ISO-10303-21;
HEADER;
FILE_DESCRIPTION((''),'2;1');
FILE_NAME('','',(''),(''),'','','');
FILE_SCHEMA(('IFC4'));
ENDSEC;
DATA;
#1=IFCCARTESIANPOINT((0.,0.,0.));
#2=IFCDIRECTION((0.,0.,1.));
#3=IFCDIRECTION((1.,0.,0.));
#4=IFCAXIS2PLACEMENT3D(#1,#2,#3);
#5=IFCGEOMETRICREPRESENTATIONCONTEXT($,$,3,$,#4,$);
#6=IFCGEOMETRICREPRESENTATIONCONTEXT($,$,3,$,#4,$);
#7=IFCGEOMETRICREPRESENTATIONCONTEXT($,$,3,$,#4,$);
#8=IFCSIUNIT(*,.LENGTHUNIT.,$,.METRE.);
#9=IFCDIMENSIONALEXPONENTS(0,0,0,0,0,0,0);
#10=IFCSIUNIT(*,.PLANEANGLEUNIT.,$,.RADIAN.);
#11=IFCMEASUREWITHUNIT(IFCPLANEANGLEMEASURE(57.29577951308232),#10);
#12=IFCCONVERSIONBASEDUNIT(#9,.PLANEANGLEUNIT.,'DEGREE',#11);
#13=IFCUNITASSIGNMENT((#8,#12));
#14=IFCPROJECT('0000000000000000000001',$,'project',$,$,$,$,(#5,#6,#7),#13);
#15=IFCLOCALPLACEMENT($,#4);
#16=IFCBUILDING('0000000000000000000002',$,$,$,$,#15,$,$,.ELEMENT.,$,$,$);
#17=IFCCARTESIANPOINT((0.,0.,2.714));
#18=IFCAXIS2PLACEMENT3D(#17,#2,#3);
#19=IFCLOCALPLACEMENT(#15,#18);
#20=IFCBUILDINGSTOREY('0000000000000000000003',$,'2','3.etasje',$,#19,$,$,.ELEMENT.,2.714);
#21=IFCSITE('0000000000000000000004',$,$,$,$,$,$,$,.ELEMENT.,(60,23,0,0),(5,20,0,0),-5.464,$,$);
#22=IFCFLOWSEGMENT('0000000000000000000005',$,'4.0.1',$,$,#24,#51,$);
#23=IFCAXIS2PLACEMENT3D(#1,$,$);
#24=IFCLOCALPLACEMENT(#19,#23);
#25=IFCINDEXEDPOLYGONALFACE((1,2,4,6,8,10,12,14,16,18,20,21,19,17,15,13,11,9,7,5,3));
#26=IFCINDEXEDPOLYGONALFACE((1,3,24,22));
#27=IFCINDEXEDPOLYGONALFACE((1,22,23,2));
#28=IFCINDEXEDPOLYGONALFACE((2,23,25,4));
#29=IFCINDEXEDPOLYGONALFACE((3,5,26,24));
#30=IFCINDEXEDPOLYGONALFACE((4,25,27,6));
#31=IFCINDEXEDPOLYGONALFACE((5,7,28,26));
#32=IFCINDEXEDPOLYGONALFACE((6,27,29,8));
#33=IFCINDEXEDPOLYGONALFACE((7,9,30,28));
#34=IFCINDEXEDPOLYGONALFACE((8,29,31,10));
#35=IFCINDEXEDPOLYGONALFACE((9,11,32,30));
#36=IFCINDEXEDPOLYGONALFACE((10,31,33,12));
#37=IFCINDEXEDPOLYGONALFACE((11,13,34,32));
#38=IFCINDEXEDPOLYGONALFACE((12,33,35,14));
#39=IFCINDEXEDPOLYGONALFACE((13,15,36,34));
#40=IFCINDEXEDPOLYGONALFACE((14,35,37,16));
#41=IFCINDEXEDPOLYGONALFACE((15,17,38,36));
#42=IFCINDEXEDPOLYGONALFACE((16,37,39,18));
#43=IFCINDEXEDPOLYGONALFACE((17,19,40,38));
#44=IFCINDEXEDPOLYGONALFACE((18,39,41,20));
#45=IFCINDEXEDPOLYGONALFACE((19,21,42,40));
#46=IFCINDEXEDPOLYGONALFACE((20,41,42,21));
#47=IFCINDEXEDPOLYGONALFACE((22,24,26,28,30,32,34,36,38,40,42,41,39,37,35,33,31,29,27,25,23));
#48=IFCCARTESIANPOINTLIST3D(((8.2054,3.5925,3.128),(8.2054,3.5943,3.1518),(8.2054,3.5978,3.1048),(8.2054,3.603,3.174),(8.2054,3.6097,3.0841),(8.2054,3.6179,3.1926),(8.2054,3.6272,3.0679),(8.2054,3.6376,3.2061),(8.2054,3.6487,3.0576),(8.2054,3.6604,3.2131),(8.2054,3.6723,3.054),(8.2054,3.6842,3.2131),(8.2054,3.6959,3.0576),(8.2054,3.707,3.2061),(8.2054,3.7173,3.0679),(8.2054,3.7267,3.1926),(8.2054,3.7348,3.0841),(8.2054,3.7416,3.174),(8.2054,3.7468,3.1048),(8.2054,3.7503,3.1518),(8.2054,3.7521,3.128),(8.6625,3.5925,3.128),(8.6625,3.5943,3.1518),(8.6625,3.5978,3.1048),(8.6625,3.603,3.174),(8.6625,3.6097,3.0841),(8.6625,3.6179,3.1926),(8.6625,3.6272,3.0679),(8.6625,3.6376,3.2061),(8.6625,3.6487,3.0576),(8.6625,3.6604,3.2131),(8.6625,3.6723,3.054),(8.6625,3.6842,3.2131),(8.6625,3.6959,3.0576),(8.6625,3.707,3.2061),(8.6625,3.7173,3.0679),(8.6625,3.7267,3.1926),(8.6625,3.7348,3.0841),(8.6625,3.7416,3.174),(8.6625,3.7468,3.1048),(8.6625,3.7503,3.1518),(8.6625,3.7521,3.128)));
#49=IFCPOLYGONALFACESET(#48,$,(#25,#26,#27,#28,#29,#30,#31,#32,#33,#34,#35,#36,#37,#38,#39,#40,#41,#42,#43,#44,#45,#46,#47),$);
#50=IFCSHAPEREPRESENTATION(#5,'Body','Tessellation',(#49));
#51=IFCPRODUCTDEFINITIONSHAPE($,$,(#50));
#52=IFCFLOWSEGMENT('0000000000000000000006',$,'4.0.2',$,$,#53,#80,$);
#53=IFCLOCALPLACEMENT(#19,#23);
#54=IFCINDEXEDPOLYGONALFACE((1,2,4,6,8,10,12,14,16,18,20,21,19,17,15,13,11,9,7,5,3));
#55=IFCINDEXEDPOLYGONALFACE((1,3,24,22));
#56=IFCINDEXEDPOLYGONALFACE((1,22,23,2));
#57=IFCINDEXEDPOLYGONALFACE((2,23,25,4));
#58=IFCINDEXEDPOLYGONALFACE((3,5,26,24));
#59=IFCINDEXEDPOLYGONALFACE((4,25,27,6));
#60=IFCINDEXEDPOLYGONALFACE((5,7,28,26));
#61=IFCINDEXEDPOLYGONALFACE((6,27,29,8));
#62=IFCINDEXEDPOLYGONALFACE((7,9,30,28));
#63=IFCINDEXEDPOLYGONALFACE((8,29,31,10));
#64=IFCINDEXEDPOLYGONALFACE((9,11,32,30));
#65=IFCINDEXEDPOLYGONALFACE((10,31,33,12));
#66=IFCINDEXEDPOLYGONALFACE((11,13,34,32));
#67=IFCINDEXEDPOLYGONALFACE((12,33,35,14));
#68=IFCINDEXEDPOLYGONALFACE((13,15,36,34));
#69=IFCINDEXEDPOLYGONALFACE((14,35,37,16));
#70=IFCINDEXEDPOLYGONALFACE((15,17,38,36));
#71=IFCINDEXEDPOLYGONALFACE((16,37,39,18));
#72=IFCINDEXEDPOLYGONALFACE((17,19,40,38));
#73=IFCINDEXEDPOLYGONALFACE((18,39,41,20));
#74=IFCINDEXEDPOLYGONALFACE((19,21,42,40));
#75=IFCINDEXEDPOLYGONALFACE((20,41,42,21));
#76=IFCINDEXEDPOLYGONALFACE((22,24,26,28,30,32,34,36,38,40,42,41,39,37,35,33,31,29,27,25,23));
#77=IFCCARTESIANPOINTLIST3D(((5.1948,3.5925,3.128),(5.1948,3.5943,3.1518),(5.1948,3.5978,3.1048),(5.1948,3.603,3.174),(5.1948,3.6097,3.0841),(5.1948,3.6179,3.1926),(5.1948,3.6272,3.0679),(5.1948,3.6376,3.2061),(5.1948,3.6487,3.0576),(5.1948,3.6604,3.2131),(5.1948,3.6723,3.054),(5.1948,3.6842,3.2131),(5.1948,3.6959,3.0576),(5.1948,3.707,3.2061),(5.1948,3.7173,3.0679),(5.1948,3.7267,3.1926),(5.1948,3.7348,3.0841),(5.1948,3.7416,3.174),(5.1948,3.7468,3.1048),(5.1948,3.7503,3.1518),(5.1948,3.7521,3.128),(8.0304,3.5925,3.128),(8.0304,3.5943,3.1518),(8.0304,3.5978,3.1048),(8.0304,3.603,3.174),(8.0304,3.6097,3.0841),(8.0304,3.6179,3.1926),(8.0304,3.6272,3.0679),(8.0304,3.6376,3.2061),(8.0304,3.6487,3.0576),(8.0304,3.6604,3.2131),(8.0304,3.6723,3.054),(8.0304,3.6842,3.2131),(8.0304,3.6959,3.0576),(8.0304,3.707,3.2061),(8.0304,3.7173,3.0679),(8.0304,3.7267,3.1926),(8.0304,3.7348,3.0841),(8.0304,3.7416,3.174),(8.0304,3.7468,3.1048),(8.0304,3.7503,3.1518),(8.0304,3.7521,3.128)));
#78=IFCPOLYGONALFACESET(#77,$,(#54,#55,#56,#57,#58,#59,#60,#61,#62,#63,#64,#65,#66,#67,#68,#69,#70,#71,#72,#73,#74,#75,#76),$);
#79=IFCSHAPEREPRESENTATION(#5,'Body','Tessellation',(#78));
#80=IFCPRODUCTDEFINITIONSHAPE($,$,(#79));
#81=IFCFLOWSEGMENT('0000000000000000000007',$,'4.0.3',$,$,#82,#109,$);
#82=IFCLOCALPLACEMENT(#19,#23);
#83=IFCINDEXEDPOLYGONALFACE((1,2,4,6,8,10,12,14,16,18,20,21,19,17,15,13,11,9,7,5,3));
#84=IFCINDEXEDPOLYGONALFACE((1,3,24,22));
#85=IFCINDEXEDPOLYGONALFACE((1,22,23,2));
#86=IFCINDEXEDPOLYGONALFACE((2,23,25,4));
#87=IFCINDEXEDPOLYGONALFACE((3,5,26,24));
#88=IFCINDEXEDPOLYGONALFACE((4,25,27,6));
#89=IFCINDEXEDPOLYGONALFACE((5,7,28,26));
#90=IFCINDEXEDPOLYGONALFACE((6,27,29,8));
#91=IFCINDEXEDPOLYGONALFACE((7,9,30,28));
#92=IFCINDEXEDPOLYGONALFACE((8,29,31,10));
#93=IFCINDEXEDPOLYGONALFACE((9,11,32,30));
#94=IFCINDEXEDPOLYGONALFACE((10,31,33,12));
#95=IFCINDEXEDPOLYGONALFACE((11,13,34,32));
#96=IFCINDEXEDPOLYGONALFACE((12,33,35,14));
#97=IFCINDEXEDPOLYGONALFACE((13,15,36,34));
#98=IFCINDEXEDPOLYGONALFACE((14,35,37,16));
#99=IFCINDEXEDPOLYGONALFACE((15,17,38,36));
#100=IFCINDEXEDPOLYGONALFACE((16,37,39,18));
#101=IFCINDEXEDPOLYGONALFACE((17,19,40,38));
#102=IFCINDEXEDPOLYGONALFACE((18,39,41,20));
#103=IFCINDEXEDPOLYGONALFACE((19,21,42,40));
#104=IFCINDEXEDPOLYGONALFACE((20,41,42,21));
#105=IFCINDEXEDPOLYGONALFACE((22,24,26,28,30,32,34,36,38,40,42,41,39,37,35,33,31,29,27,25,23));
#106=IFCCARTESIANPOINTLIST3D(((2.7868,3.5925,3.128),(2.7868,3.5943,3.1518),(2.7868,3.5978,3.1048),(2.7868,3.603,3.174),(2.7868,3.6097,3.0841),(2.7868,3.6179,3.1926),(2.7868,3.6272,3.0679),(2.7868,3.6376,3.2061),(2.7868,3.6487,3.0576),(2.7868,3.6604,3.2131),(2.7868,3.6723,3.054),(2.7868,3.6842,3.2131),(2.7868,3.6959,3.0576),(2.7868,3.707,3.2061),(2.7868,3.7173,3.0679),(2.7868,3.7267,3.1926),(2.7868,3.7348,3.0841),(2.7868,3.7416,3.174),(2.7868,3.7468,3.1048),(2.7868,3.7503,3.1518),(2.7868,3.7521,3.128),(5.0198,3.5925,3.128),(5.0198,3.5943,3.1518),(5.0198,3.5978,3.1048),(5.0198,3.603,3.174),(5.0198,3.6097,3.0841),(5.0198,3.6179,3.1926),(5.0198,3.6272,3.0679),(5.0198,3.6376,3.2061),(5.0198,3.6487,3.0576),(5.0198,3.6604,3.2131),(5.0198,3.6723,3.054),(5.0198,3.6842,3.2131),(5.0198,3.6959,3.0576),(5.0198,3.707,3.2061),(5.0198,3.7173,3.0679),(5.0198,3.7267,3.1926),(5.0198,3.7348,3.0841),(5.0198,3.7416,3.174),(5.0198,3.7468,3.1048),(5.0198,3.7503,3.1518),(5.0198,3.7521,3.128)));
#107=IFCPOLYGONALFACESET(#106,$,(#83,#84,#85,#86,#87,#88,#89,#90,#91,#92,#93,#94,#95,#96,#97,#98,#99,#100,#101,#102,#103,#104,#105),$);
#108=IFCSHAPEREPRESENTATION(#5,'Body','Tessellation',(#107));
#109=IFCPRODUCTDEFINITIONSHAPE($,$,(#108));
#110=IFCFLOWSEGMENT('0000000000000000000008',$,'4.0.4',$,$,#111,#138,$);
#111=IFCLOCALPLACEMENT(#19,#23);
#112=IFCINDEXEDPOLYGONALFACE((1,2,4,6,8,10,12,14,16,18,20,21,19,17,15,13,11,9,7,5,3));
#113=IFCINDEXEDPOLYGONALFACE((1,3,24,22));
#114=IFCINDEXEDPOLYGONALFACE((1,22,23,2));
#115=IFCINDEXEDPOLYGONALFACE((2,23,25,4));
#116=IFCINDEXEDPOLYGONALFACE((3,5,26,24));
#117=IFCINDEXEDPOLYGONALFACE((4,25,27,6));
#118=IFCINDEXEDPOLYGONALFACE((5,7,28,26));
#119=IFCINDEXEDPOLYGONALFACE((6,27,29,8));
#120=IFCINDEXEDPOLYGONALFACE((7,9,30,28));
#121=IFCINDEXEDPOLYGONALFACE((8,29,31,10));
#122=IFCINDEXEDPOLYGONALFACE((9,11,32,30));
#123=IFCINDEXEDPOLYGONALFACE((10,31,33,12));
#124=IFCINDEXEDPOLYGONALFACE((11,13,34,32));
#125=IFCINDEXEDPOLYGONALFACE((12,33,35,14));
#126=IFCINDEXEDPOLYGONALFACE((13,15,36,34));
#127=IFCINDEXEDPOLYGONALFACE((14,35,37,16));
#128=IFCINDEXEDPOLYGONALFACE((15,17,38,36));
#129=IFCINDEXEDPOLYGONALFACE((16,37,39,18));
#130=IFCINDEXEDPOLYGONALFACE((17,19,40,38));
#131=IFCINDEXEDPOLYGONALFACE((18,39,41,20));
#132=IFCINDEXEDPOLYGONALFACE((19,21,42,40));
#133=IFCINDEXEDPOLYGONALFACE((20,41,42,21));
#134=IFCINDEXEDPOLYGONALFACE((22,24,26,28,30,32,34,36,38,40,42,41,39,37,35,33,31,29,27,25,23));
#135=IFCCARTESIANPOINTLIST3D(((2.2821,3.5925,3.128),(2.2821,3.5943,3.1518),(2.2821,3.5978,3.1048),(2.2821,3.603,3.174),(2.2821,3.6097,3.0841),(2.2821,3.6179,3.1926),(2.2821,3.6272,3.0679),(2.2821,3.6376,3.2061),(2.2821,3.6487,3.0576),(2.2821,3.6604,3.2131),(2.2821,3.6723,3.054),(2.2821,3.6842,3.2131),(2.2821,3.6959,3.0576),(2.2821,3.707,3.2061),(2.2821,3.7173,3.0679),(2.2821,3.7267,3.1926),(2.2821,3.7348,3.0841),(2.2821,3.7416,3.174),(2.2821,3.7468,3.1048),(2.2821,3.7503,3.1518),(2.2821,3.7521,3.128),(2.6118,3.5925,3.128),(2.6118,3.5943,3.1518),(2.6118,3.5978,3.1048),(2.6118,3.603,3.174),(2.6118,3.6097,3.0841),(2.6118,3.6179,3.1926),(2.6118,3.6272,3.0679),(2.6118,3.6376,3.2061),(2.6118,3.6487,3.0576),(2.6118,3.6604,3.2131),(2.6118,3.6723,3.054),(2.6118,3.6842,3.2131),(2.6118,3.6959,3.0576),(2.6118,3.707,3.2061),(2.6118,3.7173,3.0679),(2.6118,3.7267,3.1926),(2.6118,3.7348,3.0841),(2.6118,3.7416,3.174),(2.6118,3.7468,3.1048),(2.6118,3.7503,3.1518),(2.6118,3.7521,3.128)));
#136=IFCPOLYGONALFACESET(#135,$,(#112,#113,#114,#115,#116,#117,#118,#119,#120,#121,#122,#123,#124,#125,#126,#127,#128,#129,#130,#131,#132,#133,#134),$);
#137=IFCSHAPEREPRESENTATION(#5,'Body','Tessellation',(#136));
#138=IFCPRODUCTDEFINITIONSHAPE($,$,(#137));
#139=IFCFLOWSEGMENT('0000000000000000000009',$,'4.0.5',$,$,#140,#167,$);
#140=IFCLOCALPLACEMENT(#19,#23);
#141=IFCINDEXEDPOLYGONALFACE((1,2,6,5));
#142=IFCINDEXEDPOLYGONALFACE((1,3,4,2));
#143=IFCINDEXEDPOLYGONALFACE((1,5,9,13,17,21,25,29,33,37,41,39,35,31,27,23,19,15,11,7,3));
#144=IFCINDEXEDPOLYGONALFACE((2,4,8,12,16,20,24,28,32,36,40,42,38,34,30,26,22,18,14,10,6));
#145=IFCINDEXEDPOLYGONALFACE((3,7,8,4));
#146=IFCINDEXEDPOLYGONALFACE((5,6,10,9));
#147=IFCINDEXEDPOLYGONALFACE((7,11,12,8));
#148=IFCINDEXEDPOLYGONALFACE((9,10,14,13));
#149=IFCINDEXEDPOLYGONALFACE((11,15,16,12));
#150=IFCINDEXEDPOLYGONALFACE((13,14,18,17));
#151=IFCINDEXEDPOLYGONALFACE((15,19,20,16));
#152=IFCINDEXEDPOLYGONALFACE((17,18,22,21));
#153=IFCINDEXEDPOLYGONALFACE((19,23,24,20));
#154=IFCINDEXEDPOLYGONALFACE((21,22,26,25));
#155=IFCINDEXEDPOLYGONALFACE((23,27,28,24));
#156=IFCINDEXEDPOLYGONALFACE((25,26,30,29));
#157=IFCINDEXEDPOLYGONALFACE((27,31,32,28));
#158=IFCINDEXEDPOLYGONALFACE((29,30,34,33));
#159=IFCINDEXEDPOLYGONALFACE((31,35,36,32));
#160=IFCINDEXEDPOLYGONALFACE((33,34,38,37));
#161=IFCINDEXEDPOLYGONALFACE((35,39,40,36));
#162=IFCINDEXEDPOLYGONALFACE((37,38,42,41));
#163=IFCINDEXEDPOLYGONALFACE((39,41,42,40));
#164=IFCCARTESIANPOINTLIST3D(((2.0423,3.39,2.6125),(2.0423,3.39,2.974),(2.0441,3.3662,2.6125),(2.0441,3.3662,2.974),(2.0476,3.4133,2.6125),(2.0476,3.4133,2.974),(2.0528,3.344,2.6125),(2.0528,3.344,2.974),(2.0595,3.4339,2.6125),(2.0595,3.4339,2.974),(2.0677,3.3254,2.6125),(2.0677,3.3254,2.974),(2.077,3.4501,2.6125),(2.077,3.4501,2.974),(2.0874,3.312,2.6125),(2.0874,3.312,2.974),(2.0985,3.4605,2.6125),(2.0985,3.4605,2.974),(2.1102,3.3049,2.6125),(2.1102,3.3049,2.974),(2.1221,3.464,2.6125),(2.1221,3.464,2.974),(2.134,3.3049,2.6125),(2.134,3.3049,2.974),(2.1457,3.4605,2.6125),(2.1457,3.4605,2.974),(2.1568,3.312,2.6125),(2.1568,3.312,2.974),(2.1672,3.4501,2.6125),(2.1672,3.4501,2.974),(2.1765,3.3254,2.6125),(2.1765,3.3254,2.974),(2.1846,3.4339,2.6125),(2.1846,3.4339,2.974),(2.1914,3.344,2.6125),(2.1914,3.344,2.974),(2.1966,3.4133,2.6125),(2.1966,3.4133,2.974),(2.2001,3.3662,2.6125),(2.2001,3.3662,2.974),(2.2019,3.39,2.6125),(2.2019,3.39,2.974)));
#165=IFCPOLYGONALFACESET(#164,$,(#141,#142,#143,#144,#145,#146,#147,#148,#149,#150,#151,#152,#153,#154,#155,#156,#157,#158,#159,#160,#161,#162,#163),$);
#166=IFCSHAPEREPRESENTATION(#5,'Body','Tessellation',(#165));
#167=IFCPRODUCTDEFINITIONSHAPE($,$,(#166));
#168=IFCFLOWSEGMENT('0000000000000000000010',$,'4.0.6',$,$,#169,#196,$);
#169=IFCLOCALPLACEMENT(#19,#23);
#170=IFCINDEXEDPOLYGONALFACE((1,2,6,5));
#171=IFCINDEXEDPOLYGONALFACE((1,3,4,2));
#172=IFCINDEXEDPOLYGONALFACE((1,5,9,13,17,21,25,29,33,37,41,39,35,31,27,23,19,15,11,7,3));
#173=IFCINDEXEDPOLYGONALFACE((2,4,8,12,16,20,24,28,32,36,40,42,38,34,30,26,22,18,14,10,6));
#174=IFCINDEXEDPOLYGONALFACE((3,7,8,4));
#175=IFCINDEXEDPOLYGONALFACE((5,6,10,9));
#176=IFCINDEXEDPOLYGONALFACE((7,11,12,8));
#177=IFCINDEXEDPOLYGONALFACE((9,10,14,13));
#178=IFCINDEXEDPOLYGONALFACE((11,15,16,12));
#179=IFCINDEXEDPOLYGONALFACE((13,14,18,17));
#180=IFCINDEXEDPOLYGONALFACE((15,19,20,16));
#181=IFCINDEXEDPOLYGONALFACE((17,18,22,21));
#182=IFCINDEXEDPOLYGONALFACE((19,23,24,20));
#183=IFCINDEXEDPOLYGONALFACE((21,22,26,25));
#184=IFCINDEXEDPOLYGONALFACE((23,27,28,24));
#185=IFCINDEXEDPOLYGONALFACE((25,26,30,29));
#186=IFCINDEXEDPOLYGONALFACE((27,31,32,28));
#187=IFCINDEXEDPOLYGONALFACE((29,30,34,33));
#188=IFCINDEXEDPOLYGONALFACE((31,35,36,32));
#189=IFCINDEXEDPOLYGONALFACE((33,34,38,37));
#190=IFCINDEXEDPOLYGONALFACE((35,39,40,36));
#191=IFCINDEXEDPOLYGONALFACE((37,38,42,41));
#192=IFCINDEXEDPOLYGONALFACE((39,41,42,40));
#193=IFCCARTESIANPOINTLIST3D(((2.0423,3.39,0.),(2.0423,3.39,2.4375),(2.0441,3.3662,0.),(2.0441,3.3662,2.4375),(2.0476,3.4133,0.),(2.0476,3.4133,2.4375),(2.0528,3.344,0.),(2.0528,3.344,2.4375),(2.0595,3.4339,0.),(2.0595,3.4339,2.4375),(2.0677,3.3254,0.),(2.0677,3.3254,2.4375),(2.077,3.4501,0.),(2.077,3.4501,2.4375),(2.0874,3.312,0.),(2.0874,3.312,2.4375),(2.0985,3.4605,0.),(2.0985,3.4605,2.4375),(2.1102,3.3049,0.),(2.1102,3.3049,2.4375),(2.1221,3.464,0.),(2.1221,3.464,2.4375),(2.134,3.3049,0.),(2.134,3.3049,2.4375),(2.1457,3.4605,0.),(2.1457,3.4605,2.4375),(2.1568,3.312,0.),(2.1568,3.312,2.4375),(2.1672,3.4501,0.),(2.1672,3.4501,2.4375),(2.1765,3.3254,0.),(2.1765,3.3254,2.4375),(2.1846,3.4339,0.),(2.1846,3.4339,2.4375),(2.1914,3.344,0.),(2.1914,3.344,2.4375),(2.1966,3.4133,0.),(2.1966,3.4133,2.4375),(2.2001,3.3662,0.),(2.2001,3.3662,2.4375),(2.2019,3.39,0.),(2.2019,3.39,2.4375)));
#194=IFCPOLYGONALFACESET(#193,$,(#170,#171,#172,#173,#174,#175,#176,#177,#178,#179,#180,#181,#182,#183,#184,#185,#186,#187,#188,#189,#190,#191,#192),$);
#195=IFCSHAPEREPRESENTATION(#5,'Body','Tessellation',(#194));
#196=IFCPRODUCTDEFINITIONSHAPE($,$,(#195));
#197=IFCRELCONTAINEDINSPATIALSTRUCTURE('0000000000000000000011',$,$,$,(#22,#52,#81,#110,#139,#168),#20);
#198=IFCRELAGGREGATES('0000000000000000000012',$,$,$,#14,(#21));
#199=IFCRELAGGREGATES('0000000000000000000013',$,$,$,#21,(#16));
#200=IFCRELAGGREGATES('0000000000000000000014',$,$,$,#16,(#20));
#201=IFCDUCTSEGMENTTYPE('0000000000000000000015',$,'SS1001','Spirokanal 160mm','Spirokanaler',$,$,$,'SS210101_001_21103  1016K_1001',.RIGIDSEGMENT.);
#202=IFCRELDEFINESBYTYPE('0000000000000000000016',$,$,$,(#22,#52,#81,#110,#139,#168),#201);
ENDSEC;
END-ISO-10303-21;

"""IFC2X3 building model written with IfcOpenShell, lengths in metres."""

from ifc_helpers import new_model, entity, si_unit, converted_unit, frame, origin_with_axes, origin_2d_with_axis, place, context, project, spatial, circle, extrude, type_object, element, save


model = new_model("IFC2X3")

# Units and contexts
context_of_model_1 = context(None, 3, world=origin_with_axes())
context_of_model_2 = context(None, 3, world=origin_with_axes())
context_of_model_3 = context(None, 3, world=origin_with_axes())
ifc_project = project(units=[si_unit("LENGTHUNIT", "METRE"), converted_unit("PLANEANGLEUNIT", "DEGREE", entity("IfcPlaneAngleMeasure", 57.29577951308232), si_unit("PLANEANGLEUNIT", "RADIAN"), dimensions=[0, 0, 0, 0, 0, 0, 0])], contexts=[context_of_model_1, context_of_model_2, context_of_model_3])

# Site, building, storey
site = spatial("IfcSite", under=ifc_project, CompositionType="ELEMENT", RefLatitude=(60, 23, 0, 0), RefLongitude=(5, 20, 0, 0), RefElevation=-5.464)
building_placement = place(None, origin_with_axes())
building = spatial("IfcBuilding", under=site, at=building_placement, CompositionType="ELEMENT")
storey_placement = place(building_placement, frame((0.0, 0.0, 2.714), z_axis=(0.0, 0.0, 1.0), x_axis=(1.0, 0.0, 0.0)))
storey = spatial("IfcBuildingStorey", under=building, at=storey_placement, Name="2", Description="3.etasje", CompositionType="ELEMENT", Elevation=2.714)

# Flow segments
duct_segment_type_1 = type_object("IfcDuctSegmentType", Name="SS1001", Description="Spirokanal 160mm", ApplicableOccurrence="Spirokanaler", ElementType="SS210101_001_21103  1016K_1001", PredefinedType="RIGIDSEGMENT")
flow_segment_1_placement = place(storey_placement, frame((8.6625, 3.6723, 3.134), z_axis=(-1.0, 0.0, 0.0), x_axis=(0.0, 0.0, -1.0)))
element("IfcFlowSegment", 1, at=flow_segment_1_placement, inside=storey, type_object=duct_segment_type_1, Name="4.0.1", context=context_of_model_1, shape_type="SweptSolid", body=[
    extrude(circle(Radius=0.08, at=origin_2d_with_axis()), origin_with_axes(), (0.0, 0.0, 1.0), 0.4571),
])
flow_segment_2_placement = place(storey_placement, frame((8.0304, 3.6723, 3.134), z_axis=(-1.0, 0.0, 0.0), x_axis=(0.0, 0.0, -1.0)))
element("IfcFlowSegment", 2, at=flow_segment_2_placement, inside=storey, type_object=duct_segment_type_1, Name="4.0.2", context=context_of_model_1, shape_type="SweptSolid", body=[
    extrude(circle(Radius=0.08, at=origin_2d_with_axis()), origin_with_axes(), (0.0, 0.0, 1.0), 2.8356),
])
flow_segment_3_placement = place(storey_placement, frame((5.0198, 3.6723, 3.134), z_axis=(-1.0, 0.0, 0.0), x_axis=(0.0, 0.0, -1.0)))
element("IfcFlowSegment", 3, at=flow_segment_3_placement, inside=storey, type_object=duct_segment_type_1, Name="4.0.3", context=context_of_model_1, shape_type="SweptSolid", body=[
    extrude(circle(Radius=0.08, at=origin_2d_with_axis()), origin_with_axes(), (0.0, 0.0, 1.0), 2.233),
])
flow_segment_4_placement = place(storey_placement, frame((2.6118, 3.6723, 3.134), z_axis=(-1.0, 0.0, 0.0), x_axis=(0.0, 0.0, -1.0)))
element("IfcFlowSegment", 4, at=flow_segment_4_placement, inside=storey, type_object=duct_segment_type_1, Name="4.0.4", context=context_of_model_1, shape_type="SweptSolid", body=[
    extrude(circle(Radius=0.08, at=origin_2d_with_axis()), origin_with_axes(), (0.0, 0.0, 1.0), 0.3297),
])
flow_segment_5_placement = place(storey_placement, frame((2.1221, 3.384, 2.974), z_axis=(0.0, 0.0, -1.0), x_axis=(0.0, 1.0, 0.0)))
element("IfcFlowSegment", 5, at=flow_segment_5_placement, inside=storey, type_object=duct_segment_type_1, Name="4.0.5", context=context_of_model_1, shape_type="SweptSolid", body=[
    extrude(circle(Radius=0.08, at=origin_2d_with_axis()), origin_with_axes(), (0.0, 0.0, 1.0), 0.3615),
])
flow_segment_6_placement = place(storey_placement, frame((2.1221, 3.384, 2.4375), z_axis=(0.0, 0.0, -1.0), x_axis=(0.0, 1.0, 0.0)))
element("IfcFlowSegment", 6, at=flow_segment_6_placement, inside=storey, type_object=duct_segment_type_1, Name="4.0.6", context=context_of_model_1, shape_type="SweptSolid", body=[
    extrude(circle(Radius=0.08, at=origin_2d_with_axis()), origin_with_axes(), (0.0, 0.0, 1.0), 2.4375),
])

save(model, "model.ifc")
